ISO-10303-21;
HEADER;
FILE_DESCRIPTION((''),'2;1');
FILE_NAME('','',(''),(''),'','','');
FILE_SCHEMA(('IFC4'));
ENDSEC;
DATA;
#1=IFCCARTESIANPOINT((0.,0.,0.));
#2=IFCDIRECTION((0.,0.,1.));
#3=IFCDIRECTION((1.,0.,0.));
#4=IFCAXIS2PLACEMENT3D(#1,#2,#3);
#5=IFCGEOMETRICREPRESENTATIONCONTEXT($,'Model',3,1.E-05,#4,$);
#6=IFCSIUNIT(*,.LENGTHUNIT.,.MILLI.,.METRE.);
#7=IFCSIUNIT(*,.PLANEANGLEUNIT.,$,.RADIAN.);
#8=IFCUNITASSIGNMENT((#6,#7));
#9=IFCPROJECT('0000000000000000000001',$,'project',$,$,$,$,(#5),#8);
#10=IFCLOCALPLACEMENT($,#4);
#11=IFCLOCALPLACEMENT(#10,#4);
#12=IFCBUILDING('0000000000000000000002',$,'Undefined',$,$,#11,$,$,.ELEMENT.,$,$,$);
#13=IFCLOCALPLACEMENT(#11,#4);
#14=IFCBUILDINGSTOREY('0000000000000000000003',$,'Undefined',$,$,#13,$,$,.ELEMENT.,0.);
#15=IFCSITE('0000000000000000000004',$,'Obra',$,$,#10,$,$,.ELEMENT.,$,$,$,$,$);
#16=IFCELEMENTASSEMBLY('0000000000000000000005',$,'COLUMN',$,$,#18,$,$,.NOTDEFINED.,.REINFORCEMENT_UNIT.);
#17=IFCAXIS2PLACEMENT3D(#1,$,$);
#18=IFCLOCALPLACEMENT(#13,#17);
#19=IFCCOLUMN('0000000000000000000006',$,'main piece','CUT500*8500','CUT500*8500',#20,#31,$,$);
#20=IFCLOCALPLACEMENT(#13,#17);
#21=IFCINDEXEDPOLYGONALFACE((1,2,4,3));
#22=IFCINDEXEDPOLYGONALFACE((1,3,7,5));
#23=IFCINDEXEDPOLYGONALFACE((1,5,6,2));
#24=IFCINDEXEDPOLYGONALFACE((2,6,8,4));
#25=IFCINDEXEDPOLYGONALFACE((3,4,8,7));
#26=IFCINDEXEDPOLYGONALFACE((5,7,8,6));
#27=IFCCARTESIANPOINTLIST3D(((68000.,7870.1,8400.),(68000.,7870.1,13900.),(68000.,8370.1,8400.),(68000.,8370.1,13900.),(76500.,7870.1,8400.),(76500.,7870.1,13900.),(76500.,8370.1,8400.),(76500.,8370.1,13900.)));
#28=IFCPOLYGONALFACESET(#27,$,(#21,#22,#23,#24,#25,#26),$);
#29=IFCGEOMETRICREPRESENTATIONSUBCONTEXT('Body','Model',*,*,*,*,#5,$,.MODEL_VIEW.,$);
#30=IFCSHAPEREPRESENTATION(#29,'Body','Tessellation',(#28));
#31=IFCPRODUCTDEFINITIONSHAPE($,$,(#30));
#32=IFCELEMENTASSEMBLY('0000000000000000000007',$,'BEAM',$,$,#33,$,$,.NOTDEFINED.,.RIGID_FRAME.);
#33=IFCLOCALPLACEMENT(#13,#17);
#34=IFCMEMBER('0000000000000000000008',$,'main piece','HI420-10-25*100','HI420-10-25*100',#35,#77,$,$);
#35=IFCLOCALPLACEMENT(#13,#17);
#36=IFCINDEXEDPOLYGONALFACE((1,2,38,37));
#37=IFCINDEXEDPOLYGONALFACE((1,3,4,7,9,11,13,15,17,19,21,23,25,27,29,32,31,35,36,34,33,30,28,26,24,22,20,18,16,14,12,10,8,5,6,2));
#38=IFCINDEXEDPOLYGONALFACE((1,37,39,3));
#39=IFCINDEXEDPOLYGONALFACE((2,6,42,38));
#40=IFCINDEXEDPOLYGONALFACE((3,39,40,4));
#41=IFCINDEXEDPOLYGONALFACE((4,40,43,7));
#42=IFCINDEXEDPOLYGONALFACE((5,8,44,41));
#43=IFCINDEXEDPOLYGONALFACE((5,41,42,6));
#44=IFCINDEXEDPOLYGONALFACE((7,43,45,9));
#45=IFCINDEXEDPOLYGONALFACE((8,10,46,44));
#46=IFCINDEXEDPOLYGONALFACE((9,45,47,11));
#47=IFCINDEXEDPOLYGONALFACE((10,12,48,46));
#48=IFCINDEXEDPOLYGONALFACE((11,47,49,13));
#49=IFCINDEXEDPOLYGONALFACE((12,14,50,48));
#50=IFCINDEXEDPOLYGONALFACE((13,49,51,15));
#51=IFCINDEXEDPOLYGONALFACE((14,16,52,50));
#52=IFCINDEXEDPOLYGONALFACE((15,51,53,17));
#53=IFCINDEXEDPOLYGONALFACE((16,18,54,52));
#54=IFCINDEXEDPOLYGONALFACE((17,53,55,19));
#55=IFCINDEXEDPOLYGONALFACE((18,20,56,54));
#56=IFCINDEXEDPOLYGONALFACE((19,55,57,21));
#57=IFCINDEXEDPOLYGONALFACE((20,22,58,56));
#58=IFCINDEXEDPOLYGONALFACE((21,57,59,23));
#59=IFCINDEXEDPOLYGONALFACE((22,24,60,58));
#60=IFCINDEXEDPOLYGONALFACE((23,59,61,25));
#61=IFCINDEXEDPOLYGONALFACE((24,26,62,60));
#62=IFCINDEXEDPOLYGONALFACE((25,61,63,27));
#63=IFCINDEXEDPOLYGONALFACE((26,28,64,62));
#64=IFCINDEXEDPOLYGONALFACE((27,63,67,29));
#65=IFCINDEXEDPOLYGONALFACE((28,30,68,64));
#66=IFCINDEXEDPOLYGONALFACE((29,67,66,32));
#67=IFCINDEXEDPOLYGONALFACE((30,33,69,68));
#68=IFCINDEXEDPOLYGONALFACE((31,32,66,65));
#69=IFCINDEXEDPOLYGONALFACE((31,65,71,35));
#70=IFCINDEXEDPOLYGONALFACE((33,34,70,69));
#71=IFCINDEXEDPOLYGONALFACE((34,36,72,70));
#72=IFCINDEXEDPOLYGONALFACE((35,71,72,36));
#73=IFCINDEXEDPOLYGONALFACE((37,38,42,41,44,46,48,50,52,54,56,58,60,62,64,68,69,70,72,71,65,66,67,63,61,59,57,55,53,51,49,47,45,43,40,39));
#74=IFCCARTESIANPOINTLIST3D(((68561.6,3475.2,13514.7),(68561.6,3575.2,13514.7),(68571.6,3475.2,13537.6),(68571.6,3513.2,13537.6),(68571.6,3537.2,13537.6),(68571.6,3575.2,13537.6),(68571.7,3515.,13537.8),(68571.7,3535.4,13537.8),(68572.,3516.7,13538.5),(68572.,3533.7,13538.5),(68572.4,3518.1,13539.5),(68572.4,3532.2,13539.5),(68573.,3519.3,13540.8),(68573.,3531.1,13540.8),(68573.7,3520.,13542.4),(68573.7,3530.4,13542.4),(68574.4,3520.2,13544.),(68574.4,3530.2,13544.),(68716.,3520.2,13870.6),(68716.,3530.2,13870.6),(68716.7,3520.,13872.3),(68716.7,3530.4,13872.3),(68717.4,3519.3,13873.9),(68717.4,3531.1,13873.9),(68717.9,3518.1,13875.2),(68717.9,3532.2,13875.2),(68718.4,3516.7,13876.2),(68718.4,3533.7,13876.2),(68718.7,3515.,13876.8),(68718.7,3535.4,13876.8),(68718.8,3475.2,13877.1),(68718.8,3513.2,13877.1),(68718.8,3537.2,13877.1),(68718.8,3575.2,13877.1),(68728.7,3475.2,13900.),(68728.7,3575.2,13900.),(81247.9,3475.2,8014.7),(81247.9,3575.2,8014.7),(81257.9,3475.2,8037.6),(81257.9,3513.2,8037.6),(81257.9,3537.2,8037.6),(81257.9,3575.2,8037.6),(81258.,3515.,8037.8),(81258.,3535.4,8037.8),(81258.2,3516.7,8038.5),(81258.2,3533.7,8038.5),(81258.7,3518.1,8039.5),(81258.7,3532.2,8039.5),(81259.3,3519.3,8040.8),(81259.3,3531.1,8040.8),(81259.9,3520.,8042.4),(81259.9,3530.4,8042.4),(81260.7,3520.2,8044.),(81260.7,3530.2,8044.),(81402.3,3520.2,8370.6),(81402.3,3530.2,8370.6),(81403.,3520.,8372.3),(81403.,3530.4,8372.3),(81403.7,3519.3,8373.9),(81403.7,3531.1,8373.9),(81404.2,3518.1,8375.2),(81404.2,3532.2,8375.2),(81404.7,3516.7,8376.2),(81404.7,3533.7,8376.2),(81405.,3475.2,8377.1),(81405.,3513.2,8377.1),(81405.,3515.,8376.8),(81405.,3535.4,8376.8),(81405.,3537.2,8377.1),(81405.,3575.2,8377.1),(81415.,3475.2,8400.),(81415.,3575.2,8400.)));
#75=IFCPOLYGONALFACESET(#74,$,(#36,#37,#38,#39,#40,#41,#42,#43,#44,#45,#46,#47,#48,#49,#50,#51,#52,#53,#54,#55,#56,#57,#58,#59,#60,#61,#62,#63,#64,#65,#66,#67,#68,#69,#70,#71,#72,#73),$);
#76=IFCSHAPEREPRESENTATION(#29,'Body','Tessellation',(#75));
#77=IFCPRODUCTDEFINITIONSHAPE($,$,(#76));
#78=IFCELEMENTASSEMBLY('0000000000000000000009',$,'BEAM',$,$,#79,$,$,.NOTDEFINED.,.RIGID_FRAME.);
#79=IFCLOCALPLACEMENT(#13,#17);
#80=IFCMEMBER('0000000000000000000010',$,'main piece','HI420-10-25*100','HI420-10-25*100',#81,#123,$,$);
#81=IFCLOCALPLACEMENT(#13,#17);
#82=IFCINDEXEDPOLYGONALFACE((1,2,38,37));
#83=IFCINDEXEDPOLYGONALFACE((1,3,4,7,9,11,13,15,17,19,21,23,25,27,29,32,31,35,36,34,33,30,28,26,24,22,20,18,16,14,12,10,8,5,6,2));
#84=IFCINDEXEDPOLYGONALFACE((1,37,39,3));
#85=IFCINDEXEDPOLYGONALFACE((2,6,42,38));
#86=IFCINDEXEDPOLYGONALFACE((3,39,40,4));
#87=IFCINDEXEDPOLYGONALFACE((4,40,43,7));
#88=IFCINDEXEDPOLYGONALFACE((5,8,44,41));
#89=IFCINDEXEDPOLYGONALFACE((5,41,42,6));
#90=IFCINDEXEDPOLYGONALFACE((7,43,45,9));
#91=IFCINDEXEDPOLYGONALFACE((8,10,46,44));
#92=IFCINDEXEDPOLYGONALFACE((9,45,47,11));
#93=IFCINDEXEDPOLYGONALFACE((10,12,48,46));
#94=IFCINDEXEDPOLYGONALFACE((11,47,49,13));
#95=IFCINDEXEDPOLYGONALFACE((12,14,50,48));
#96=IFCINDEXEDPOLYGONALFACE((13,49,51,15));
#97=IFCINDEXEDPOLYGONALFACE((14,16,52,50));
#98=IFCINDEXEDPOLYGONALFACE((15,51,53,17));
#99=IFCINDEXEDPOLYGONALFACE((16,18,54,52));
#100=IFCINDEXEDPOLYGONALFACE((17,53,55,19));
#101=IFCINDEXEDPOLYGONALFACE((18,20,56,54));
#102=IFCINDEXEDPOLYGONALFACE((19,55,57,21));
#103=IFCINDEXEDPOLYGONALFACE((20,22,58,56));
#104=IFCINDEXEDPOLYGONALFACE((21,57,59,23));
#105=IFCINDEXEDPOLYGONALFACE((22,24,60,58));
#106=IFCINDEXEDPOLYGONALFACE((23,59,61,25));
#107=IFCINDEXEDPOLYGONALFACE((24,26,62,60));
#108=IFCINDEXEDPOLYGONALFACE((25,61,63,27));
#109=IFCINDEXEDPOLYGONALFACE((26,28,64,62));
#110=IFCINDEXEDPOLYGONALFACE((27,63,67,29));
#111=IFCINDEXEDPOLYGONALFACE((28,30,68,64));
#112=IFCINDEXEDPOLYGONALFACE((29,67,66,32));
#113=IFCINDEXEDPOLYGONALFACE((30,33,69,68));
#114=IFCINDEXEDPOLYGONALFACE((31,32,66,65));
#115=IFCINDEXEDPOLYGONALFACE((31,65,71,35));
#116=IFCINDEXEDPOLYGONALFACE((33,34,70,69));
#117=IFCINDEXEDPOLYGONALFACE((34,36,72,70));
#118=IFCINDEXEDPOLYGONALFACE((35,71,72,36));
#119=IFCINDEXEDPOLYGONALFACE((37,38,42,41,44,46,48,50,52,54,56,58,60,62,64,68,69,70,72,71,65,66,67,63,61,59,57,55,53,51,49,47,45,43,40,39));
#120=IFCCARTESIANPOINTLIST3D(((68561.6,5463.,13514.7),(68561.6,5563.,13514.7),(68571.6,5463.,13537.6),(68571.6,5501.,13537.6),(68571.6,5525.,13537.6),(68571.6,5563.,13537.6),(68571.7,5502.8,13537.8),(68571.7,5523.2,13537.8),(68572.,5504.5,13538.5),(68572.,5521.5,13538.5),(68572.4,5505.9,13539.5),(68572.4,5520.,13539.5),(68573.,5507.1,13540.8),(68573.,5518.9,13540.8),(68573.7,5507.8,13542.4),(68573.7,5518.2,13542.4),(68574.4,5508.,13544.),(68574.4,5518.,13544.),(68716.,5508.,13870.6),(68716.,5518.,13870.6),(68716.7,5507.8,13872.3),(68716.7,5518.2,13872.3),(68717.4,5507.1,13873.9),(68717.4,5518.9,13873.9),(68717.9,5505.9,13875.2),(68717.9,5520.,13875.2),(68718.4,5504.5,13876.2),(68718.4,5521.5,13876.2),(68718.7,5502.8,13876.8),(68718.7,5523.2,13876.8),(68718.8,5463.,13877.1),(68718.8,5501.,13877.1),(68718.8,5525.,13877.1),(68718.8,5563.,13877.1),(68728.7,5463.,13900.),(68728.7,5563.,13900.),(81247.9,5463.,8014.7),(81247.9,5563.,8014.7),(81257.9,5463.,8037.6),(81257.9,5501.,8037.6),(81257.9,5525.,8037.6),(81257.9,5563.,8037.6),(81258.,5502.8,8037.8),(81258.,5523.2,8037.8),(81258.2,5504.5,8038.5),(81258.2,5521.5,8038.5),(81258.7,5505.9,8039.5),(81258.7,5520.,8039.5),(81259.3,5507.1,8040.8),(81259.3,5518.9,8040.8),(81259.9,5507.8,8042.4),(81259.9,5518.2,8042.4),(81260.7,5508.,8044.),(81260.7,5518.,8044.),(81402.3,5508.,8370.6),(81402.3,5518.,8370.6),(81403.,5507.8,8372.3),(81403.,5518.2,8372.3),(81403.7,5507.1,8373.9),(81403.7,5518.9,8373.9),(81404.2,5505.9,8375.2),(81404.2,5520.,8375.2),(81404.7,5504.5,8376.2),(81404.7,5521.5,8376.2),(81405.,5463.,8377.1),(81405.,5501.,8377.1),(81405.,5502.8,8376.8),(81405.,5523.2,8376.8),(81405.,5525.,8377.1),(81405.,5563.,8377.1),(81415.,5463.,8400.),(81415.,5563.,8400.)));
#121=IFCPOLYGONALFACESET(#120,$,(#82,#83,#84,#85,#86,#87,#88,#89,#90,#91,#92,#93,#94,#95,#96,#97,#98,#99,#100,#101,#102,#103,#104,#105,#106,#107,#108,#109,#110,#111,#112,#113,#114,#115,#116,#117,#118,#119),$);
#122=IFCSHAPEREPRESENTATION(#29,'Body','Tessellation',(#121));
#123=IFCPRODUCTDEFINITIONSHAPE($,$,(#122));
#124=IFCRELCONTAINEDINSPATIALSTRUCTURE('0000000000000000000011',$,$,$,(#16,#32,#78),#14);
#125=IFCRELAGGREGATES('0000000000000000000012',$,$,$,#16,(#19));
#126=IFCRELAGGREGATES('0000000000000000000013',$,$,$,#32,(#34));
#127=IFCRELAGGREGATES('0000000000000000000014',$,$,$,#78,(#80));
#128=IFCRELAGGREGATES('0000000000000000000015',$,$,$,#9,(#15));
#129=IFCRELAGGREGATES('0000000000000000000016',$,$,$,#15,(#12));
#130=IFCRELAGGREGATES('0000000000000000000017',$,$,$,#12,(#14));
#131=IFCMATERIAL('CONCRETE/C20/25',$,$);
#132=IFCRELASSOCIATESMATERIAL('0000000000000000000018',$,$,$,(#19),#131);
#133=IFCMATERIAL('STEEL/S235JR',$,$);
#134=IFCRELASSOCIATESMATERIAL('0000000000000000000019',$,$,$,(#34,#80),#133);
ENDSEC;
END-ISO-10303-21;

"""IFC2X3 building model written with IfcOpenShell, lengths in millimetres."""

from ifc_helpers import new_model, si_unit, frame, origin_with_axes, origin_2d_with_axis, place, context, subcontext, project, spatial, rectangle, i_section, extrude, material, element, aggregate, save


model = new_model("IFC2X3")

# Units and contexts
model_context = context("Model", 3, precision=1e-05, world=origin_with_axes())
body_context = subcontext(model_context, "Body", "Model", "MODEL_VIEW")
ifc_project = project(units=[si_unit("LENGTHUNIT", "METRE", prefix="MILLI"), si_unit("PLANEANGLEUNIT", "RADIAN")], contexts=[model_context])

# Site, building, storey
site_placement = place(None, origin_with_axes())
site = spatial("IfcSite", under=ifc_project, at=site_placement, Name="Obra", CompositionType="ELEMENT")
building_placement = place(site_placement, origin_with_axes())
building = spatial("IfcBuilding", under=site, at=building_placement, Name="Undefined", CompositionType="ELEMENT")
storey_placement = place(building_placement, origin_with_axes())
storey = spatial("IfcBuildingStorey", under=building, at=storey_placement, Name="Undefined", CompositionType="ELEMENT", Elevation=0.0)

# Element assembly, column
assembly_1_placement = place(storey_placement, origin_with_axes())
assembly_1 = element("IfcElementAssembly", 1, at=assembly_1_placement, inside=storey, Name="COLUMN", AssemblyPlace="NOTDEFINED", PredefinedType="REINFORCEMENT_UNIT")
ifc_material_1 = material(Name="CONCRETE/C20/25")
column_placement = place(assembly_1_placement, frame((72250.0, 8120.1, 8400.0), z_axis=(0.0, 0.0, 1.0), x_axis=(-1.0, 0.0, 0.0)))
column = element("IfcColumn", 2, at=column_placement, material=ifc_material_1, Name="main piece", Description="CUT500*8500", ObjectType="CUT500*8500", context=body_context, shape_type="SweptSolid", body=[
    extrude(rectangle(XDim=500.0, YDim=8500.0, at=origin_2d_with_axis()), frame((0.0, 0.0, 5500.0), z_axis=(0.0, 0.0, -1.0), x_axis=(0.0, 1.0, 0.0)), (0.0, 0.0, 1.0), 5500.0),
])
aggregate(assembly_1, [column])

# Element assemblies, members
assembly_2_placement = place(storey_placement, origin_with_axes())
assembly_2 = element("IfcElementAssembly", 3, at=assembly_2_placement, inside=storey, Name="BEAM", AssemblyPlace="NOTDEFINED", PredefinedType="RIGID_FRAME")
ifc_material_2 = material(Name="STEEL/S235JR")
member_1_placement = place(assembly_2_placement, frame((68645.2, 3525.2, 13707.3), z_axis=(0.397766, 0.0, 0.917487), x_axis=(0.917487, 0.0, -0.397766)))
member_1 = element("IfcMember", 4, at=member_1_placement, material=ifc_material_2, Name="main piece", Description="HI420-10-25*100", ObjectType="HI420-10-25*100", context=body_context, shape_type="SweptSolid", body=[
    extrude(i_section(OverallWidth=100.0, OverallDepth=420.0, WebThickness=10.0, FlangeThickness=25.0, FilletRadius=7.0, at=origin_2d_with_axis()), frame((13827.2, 0.0, 0.0), z_axis=(-1.0, 0.0, 0.0), x_axis=(0.0, -1.0, 0.0)), (0.0, 0.0, 1.0), 13827.2),
])
aggregate(assembly_2, [member_1])
assembly_3_placement = place(storey_placement, origin_with_axes())
assembly_3 = element("IfcElementAssembly", 5, at=assembly_3_placement, inside=storey, Name="BEAM", AssemblyPlace="NOTDEFINED", PredefinedType="RIGID_FRAME")
member_2_placement = place(assembly_3_placement, frame((68645.2, 5513.0, 13707.3), z_axis=(0.397766, 0.0, 0.917487), x_axis=(0.917487, 0.0, -0.397766)))
member_2 = element("IfcMember", 6, at=member_2_placement, material=ifc_material_2, Name="main piece", Description="HI420-10-25*100", ObjectType="HI420-10-25*100", context=body_context, shape_type="SweptSolid", body=[
    extrude(i_section(OverallWidth=100.0, OverallDepth=420.0, WebThickness=10.0, FlangeThickness=25.0, FilletRadius=7.0, at=origin_2d_with_axis()), frame((13827.2, 0.0, 0.0), z_axis=(-1.0, 0.0, 0.0), x_axis=(0.0, -1.0, 0.0)), (0.0, 0.0, 1.0), 13827.2),
])
aggregate(assembly_3, [member_2])

save(model, "model.ifc")
